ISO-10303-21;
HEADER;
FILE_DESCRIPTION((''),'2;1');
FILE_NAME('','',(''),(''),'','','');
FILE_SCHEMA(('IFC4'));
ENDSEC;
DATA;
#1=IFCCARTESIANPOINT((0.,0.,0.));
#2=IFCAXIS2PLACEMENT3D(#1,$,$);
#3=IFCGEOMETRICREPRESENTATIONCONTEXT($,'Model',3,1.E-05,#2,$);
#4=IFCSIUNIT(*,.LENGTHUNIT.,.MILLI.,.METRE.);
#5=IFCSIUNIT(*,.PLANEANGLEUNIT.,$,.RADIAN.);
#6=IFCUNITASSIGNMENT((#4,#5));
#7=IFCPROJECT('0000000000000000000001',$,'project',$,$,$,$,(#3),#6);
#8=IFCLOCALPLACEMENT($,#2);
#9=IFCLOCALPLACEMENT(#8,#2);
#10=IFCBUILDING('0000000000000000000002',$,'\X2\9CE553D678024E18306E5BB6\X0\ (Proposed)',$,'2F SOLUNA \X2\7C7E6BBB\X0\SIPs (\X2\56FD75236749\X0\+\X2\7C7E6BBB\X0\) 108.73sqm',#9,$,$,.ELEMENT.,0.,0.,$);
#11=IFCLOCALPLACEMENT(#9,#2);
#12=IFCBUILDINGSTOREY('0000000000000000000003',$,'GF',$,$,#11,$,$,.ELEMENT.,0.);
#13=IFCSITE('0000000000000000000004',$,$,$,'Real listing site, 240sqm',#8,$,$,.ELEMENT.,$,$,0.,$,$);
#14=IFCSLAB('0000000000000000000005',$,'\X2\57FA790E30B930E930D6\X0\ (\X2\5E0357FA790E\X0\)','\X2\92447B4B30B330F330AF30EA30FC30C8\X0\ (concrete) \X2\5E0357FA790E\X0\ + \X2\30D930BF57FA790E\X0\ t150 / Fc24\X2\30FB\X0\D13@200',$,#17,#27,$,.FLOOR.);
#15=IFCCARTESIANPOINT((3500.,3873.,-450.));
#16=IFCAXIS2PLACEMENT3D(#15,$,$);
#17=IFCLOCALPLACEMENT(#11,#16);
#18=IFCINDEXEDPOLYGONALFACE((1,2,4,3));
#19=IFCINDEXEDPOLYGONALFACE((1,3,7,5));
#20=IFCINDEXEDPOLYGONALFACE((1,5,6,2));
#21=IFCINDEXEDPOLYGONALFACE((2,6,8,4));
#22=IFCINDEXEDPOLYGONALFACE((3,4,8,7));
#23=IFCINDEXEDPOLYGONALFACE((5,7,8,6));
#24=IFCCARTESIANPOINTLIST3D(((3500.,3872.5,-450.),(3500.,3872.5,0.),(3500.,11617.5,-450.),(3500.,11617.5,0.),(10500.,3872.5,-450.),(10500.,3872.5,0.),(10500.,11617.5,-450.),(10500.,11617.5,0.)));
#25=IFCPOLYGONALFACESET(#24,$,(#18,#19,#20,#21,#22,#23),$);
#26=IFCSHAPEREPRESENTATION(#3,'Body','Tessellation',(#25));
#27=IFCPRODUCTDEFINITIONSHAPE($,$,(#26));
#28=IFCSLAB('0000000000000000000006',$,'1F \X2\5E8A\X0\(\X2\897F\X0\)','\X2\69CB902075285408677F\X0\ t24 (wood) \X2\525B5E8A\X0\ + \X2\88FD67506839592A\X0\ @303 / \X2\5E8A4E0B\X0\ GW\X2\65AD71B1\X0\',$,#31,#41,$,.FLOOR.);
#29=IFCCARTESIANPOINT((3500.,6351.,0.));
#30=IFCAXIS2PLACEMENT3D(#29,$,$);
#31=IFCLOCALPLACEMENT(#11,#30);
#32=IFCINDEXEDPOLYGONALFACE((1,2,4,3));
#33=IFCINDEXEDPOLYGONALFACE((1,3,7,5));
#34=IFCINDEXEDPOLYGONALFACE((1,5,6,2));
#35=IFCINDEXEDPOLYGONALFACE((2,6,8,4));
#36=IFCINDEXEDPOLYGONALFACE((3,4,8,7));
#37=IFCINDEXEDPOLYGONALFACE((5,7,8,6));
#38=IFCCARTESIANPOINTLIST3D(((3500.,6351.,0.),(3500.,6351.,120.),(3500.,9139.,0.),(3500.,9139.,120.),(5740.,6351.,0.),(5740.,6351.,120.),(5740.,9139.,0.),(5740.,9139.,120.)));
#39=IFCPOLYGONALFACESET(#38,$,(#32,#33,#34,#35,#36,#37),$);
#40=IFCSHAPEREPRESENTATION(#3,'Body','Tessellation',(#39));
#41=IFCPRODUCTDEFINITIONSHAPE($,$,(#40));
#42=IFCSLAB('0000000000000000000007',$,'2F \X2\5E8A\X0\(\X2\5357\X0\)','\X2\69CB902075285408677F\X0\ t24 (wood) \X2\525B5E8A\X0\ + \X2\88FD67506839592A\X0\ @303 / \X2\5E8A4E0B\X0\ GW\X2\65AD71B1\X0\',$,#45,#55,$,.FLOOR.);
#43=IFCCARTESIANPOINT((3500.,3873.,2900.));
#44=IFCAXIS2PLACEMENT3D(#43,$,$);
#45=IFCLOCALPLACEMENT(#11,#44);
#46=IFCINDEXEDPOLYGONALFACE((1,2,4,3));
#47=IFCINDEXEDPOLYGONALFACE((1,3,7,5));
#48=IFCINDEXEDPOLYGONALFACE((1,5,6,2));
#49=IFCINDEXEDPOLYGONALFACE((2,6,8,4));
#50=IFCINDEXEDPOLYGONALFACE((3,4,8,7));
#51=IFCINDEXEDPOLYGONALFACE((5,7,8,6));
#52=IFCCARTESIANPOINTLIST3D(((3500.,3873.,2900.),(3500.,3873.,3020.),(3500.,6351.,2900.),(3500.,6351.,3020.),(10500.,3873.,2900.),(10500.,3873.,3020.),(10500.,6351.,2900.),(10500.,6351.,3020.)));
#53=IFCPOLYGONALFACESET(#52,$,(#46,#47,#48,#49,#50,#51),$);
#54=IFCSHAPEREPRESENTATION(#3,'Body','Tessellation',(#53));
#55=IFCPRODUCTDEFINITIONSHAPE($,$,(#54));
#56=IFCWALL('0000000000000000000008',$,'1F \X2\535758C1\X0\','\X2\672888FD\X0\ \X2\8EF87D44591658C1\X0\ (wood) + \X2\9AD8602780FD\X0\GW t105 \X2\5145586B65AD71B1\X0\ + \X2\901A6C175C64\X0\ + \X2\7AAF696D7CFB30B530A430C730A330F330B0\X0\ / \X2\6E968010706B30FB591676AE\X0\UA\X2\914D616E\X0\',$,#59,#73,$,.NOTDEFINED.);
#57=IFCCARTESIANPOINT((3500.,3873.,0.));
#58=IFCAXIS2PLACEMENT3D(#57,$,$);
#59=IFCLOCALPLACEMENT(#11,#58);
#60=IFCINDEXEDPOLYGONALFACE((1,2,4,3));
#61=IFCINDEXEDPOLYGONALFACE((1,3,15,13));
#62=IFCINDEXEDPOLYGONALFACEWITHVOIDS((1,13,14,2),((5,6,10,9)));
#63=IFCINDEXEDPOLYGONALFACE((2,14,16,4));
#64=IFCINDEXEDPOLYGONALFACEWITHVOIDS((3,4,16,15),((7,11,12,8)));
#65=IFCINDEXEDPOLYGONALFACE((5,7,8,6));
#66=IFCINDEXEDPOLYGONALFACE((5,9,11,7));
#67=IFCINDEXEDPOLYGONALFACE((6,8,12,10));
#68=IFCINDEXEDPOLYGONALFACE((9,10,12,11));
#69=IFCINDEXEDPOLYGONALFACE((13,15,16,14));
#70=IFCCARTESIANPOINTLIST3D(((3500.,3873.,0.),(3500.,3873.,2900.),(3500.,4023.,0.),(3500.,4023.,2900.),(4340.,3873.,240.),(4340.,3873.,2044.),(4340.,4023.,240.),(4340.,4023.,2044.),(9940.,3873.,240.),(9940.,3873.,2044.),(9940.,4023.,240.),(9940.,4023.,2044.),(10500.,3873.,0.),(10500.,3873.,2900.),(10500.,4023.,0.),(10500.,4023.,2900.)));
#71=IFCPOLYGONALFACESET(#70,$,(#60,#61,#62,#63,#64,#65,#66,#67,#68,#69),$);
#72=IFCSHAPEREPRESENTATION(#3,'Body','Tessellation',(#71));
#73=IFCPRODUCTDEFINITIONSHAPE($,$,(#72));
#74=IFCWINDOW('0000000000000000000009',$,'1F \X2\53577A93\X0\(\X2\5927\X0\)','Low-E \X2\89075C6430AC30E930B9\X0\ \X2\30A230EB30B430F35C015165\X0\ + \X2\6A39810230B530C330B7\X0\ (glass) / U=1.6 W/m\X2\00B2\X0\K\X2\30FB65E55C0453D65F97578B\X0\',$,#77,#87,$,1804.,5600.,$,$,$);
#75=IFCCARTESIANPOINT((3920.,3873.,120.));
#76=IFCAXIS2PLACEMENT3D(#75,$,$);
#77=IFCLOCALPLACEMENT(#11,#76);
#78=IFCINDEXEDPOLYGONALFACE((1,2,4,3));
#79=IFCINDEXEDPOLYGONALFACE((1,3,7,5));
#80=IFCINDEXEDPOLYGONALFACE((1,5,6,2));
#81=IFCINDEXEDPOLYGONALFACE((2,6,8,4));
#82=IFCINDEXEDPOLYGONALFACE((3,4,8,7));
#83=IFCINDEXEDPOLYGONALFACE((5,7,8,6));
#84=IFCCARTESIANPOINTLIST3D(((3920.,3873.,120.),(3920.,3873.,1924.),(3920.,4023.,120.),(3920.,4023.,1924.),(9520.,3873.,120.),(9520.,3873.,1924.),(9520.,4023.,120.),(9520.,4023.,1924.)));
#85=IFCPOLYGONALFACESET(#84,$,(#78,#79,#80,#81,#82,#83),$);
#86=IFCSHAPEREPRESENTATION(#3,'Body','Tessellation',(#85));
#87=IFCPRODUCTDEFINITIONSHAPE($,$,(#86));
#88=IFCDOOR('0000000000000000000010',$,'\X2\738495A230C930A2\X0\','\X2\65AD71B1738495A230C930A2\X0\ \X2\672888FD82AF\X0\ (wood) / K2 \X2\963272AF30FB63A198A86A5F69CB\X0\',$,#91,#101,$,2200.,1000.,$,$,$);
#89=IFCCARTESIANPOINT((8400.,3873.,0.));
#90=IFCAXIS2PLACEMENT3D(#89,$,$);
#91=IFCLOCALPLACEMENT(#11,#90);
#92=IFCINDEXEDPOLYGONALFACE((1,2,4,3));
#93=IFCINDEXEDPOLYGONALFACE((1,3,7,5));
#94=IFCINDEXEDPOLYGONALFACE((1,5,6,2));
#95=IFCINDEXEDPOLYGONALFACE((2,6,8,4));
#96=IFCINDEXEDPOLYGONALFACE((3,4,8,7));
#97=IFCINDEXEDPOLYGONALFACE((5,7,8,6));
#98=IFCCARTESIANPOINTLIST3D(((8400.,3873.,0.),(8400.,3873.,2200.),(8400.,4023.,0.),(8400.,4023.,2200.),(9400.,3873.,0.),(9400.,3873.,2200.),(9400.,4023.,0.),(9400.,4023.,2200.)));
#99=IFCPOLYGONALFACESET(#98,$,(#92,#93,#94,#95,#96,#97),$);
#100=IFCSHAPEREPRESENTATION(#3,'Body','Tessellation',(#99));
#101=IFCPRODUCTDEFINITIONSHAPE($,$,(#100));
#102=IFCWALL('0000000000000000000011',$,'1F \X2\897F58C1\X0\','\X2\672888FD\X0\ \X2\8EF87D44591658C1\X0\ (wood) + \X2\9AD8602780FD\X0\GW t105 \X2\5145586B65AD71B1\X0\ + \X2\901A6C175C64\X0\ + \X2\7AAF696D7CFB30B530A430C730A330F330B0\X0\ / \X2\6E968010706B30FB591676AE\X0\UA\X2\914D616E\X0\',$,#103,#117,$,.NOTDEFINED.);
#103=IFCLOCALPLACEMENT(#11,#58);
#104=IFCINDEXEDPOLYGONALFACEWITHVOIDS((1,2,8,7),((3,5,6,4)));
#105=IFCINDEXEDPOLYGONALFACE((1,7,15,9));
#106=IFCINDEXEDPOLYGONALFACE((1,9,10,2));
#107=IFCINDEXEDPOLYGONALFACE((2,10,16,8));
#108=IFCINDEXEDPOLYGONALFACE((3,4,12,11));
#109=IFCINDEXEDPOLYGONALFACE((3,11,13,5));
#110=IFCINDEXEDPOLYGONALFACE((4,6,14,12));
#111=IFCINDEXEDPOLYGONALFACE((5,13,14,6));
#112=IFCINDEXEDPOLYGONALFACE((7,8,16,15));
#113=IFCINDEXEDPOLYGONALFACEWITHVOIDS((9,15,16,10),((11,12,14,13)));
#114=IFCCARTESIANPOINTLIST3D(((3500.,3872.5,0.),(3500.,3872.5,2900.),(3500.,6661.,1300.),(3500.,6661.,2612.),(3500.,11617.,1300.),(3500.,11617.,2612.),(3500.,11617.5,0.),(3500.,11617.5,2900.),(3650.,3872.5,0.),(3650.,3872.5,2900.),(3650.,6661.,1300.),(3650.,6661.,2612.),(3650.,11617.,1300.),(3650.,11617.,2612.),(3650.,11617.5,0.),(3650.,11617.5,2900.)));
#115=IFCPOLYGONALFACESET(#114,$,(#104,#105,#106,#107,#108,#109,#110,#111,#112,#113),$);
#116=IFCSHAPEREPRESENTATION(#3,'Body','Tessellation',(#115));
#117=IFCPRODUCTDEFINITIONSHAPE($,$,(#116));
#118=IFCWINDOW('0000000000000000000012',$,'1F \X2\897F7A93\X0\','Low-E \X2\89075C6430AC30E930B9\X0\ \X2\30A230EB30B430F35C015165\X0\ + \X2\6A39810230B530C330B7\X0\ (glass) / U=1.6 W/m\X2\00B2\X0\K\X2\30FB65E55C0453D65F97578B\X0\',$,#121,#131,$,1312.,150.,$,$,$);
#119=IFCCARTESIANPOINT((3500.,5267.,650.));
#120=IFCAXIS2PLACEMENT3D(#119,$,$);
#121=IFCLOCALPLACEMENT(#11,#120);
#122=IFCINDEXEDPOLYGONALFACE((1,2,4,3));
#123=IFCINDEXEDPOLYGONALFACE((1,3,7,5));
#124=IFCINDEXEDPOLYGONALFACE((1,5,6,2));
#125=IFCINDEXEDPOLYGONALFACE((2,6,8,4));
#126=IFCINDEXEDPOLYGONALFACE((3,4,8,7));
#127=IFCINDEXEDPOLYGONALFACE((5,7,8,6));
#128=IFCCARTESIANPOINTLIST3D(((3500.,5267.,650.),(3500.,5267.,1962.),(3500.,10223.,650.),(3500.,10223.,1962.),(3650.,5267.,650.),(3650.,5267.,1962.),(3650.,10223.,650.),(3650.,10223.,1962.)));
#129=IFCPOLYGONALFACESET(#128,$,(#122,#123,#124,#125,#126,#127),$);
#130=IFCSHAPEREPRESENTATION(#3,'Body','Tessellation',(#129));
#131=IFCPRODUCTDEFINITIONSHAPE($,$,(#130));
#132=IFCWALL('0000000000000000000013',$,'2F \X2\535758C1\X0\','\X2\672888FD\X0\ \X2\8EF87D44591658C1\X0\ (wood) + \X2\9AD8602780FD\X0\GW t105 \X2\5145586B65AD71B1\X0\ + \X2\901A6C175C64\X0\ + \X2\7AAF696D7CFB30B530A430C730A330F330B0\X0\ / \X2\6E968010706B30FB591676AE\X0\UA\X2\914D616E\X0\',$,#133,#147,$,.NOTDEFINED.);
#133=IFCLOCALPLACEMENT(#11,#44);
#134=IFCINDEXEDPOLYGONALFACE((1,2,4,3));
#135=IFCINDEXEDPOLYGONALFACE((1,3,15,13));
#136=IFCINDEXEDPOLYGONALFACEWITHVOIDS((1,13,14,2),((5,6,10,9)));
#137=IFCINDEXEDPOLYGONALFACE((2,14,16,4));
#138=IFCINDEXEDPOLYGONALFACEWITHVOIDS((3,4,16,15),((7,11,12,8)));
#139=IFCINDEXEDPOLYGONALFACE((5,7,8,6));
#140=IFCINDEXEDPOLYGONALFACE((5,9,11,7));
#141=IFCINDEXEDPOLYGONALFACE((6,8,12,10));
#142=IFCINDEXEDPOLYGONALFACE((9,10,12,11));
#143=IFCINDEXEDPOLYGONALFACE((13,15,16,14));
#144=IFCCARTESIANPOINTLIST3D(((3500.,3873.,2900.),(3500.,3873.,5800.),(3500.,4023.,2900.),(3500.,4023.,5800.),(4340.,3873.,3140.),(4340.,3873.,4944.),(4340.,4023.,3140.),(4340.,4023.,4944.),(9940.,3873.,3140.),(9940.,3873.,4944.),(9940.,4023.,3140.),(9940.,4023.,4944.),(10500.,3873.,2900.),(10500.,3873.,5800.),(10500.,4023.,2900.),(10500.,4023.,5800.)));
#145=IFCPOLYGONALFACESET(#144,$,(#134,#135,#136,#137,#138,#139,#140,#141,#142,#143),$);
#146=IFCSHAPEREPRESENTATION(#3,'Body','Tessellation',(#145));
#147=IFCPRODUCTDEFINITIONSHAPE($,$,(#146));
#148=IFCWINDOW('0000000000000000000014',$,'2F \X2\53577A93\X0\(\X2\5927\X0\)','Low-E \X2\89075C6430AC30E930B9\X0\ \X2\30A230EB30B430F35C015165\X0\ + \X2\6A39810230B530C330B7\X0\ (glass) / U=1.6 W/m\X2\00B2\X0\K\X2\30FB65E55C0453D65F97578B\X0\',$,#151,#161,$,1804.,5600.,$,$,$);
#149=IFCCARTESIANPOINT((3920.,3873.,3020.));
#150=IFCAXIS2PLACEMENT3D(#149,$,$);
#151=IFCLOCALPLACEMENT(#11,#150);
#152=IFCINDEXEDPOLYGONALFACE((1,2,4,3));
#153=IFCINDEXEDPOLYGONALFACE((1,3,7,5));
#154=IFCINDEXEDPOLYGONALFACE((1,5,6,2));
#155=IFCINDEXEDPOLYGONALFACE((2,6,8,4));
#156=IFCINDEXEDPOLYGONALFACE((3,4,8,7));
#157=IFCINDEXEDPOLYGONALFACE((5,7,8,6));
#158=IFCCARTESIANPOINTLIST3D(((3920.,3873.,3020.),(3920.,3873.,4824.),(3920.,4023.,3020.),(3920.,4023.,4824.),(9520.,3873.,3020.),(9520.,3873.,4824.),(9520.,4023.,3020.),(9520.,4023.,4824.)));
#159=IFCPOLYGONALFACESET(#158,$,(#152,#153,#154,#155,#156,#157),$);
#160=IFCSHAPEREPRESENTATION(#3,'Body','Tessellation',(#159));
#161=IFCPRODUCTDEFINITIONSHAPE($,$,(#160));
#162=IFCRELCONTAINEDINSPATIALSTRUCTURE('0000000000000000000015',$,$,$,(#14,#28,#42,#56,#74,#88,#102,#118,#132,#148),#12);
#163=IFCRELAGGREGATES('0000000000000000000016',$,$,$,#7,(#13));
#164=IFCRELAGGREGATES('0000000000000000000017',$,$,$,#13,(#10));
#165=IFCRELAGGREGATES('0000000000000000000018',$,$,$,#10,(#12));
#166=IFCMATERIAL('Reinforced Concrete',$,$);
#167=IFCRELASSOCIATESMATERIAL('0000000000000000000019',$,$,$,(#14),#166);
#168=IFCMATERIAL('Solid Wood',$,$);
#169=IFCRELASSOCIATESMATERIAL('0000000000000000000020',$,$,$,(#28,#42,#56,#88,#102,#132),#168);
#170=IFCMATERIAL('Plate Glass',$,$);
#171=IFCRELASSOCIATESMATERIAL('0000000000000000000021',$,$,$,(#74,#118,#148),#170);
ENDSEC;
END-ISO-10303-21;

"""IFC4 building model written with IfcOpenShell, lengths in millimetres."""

from ifc_helpers import new_model, si_unit, frame, frame_2d, origin, place, context, project, spatial, rectangle, extrude, material, element, fill, save


model = new_model("IFC4")

# Units and contexts
model_context = context("Model", 3, precision=1e-05, world=origin())
ifc_project = project(units=[si_unit("LENGTHUNIT", "METRE", prefix="MILLI"), si_unit("PLANEANGLEUNIT", "RADIAN")], contexts=[model_context])

# Site, building, storey
site_placement = place(None, origin())
site = spatial("IfcSite", under=ifc_project, at=site_placement, ObjectType="Real listing site, 240sqm", CompositionType="ELEMENT", RefElevation=0.0)
building_placement = place(site_placement, origin())
building = spatial("IfcBuilding", under=site, at=building_placement, Name="鳥取砂丘の家 (Proposed)", ObjectType="2F SOLUNA 籾殻SIPs (国産杉+籾殻) 108.73sqm", CompositionType="ELEMENT", ElevationOfRefHeight=0.0, ElevationOfTerrain=0.0)
storey_placement = place(building_placement, origin())
storey = spatial("IfcBuildingStorey", under=building, at=storey_placement, Name="GF", CompositionType="ELEMENT", Elevation=0.0)

# Slabs
ifc_material_1 = material(Name="Reinforced Concrete")
slab_1_placement = place(storey_placement, frame((3500.0, 3873.0, -450.0)))
element("IfcSlab", 1, at=slab_1_placement, inside=storey, material=ifc_material_1, Name="基礎スラブ (布基礎)", Description="鉄筋コンクリート (concrete) 布基礎 + ベタ基礎 t150 / Fc24・D13@200", PredefinedType="FLOOR", context=model_context, shape_type="SweptSolid", body=[
    extrude(rectangle(XDim=7000.0, YDim=7745.0, at=frame_2d((3500.0, 3872.0))), frame((3500.0, 3873.0, -450.0)), (0.0, 0.0, 1.0), 450.0),
])
ifc_material_2 = material(Name="Solid Wood")
slab_2_placement = place(storey_placement, frame((3500.0, 6351.0, 0.0)))
element("IfcSlab", 2, at=slab_2_placement, inside=storey, material=ifc_material_2, Name="1F 床(西)", Description="構造用合板 t24 (wood) 剛床 + 製材根太 @303 / 床下 GW断熱", PredefinedType="FLOOR", context=model_context, shape_type="SweptSolid", body=[
    extrude(rectangle(XDim=2240.0, YDim=2788.0, at=frame_2d((1120.0, 1394.0))), frame((3500.0, 6351.0, 0.0)), (0.0, 0.0, 1.0), 120.0),
])
slab_3_placement = place(storey_placement, frame((3500.0, 3873.0, 2900.0)))
element("IfcSlab", 3, at=slab_3_placement, inside=storey, material=ifc_material_2, Name="2F 床(南)", Description="構造用合板 t24 (wood) 剛床 + 製材根太 @303 / 床下 GW断熱", PredefinedType="FLOOR", context=model_context, shape_type="SweptSolid", body=[
    extrude(rectangle(XDim=7000.0, YDim=2478.0, at=frame_2d((3500.0, 1239.0))), frame((3500.0, 3873.0, 2900.0)), (0.0, 0.0, 1.0), 120.0),
])

# Wall, openings, window, door
wall_1_placement = place(storey_placement, frame((3500.0, 3873.0, 0.0)))
wall_1 = element("IfcWall", 4, at=wall_1_placement, inside=storey, material=ifc_material_2, Name="1F 南壁", Description="木製 軸組外壁 (wood) + 高性能GW t105 充填断熱 + 通気層 + 窯業系サイディング / 準耐火・外皮UA配慮", PredefinedType="NOTDEFINED", context=model_context, shape_type="SweptSolid", body=[
    extrude(rectangle(XDim=7000.0, YDim=150.0, at=frame_2d((3500.0, 75.0))), frame((3500.0, 3873.0, 0.0)), (0.0, 0.0, 1.0), 2900.0),
])
opening_1_placement = place(storey_placement, frame((3920.0, 3873.0, 120.0)))
opening_1 = element("IfcOpeningElement", 5, at=opening_1_placement, cuts=wall_1, PredefinedType="NOTDEFINED", context=model_context, shape_type="SweptSolid", body=[
    extrude(rectangle(XDim=5600.0, YDim=150.0, at=frame_2d((2800.0, 75.0))), frame((3920.0, 3873.0, 120.0)), (0.0, 0.0, 1.0), 1804.0),
])
opening_2_placement = place(storey_placement, frame((8400.0, 3873.0, 0.0)))
opening_2 = element("IfcOpeningElement", 6, at=opening_2_placement, cuts=wall_1, PredefinedType="NOTDEFINED", context=model_context, shape_type="SweptSolid", body=[
    extrude(rectangle(XDim=1000.0, YDim=150.0, at=frame_2d((500.0, 75.0))), frame((8400.0, 3873.0, 0.0)), (0.0, 0.0, 1.0), 2200.0),
])
ifc_material_3 = material(Name="Plate Glass")
window_1_placement = place(storey_placement, frame((3920.0, 3873.0, 120.0)))
window_1 = element("IfcWindow", 7, at=window_1_placement, inside=storey, material=ifc_material_3, Name="1F 南窓(大)", Description="Low-E 複層ガラス アルゴン封入 + 樹脂サッシ (glass) / U=1.6 W/m²K・日射取得型", OverallHeight=1804.0, OverallWidth=5600.0, context=model_context, shape_type="SweptSolid", body=[
    extrude(rectangle(XDim=5600.0, YDim=150.0, at=frame_2d((2800.0, 75.0))), frame((3920.0, 3873.0, 120.0)), (0.0, 0.0, 1.0), 1804.0),
])
fill(opening_1, window_1)
door_placement = place(storey_placement, frame((8400.0, 3873.0, 0.0)))
door = element("IfcDoor", 8, at=door_placement, inside=storey, material=ifc_material_2, Name="玄関ドア", Description="断熱玄関ドア 木製芯 (wood) / K2 防犯・採風機構", OverallHeight=2200.0, OverallWidth=1000.0, context=model_context, shape_type="SweptSolid", body=[
    extrude(rectangle(XDim=1000.0, YDim=150.0, at=frame_2d((500.0, 75.0))), frame((8400.0, 3873.0, 0.0)), (0.0, 0.0, 1.0), 2200.0),
])
fill(opening_2, door)

# Walls, openings, windows
wall_2_placement = place(storey_placement, frame((3500.0, 3873.0, 0.0)))
wall_2 = element("IfcWall", 9, at=wall_2_placement, inside=storey, material=ifc_material_2, Name="1F 西壁", Description="木製 軸組外壁 (wood) + 高性能GW t105 充填断熱 + 通気層 + 窯業系サイディング / 準耐火・外皮UA配慮", PredefinedType="NOTDEFINED", context=model_context, shape_type="SweptSolid", body=[
    extrude(rectangle(XDim=150.0, YDim=7745.0, at=frame_2d((75.0, 3872.0))), frame((3500.0, 3873.0, 0.0)), (0.0, 0.0, 1.0), 2900.0),
])
opening_3_placement = place(storey_placement, frame((3500.0, 5267.0, 650.0)))
opening_3 = element("IfcOpeningElement", 10, at=opening_3_placement, cuts=wall_2, PredefinedType="NOTDEFINED", context=model_context, shape_type="SweptSolid", body=[
    extrude(rectangle(XDim=150.0, YDim=4956.0, at=frame_2d((75.0, 2478.0))), frame((3500.0, 5267.0, 650.0)), (0.0, 0.0, 1.0), 1312.0),
])
window_2_placement = place(storey_placement, frame((3500.0, 5267.0, 650.0)))
window_2 = element("IfcWindow", 11, at=window_2_placement, inside=storey, material=ifc_material_3, Name="1F 西窓", Description="Low-E 複層ガラス アルゴン封入 + 樹脂サッシ (glass) / U=1.6 W/m²K・日射取得型", OverallHeight=1312.0, OverallWidth=150.0, context=model_context, shape_type="SweptSolid", body=[
    extrude(rectangle(XDim=150.0, YDim=4956.0, at=frame_2d((75.0, 2478.0))), frame((3500.0, 5267.0, 650.0)), (0.0, 0.0, 1.0), 1312.0),
])
fill(opening_3, window_2)
wall_3_placement = place(storey_placement, frame((3500.0, 3873.0, 2900.0)))
wall_3 = element("IfcWall", 12, at=wall_3_placement, inside=storey, material=ifc_material_2, Name="2F 南壁", Description="木製 軸組外壁 (wood) + 高性能GW t105 充填断熱 + 通気層 + 窯業系サイディング / 準耐火・外皮UA配慮", PredefinedType="NOTDEFINED", context=model_context, shape_type="SweptSolid", body=[
    extrude(rectangle(XDim=7000.0, YDim=150.0, at=frame_2d((3500.0, 75.0))), frame((3500.0, 3873.0, 2900.0)), (0.0, 0.0, 1.0), 2900.0),
])
opening_4_placement = place(storey_placement, frame((3920.0, 3873.0, 3020.0)))
opening_4 = element("IfcOpeningElement", 13, at=opening_4_placement, cuts=wall_3, PredefinedType="NOTDEFINED", context=model_context, shape_type="SweptSolid", body=[
    extrude(rectangle(XDim=5600.0, YDim=150.0, at=frame_2d((2800.0, 75.0))), frame((3920.0, 3873.0, 3020.0)), (0.0, 0.0, 1.0), 1804.0),
])
window_3_placement = place(storey_placement, frame((3920.0, 3873.0, 3020.0)))
window_3 = element("IfcWindow", 14, at=window_3_placement, inside=storey, material=ifc_material_3, Name="2F 南窓(大)", Description="Low-E 複層ガラス アルゴン封入 + 樹脂サッシ (glass) / U=1.6 W/m²K・日射取得型", OverallHeight=1804.0, OverallWidth=5600.0, context=model_context, shape_type="SweptSolid", body=[
    extrude(rectangle(XDim=5600.0, YDim=150.0, at=frame_2d((2800.0, 75.0))), frame((3920.0, 3873.0, 3020.0)), (0.0, 0.0, 1.0), 1804.0),
])
fill(opening_4, window_3)

save(model, "model.ifc")
